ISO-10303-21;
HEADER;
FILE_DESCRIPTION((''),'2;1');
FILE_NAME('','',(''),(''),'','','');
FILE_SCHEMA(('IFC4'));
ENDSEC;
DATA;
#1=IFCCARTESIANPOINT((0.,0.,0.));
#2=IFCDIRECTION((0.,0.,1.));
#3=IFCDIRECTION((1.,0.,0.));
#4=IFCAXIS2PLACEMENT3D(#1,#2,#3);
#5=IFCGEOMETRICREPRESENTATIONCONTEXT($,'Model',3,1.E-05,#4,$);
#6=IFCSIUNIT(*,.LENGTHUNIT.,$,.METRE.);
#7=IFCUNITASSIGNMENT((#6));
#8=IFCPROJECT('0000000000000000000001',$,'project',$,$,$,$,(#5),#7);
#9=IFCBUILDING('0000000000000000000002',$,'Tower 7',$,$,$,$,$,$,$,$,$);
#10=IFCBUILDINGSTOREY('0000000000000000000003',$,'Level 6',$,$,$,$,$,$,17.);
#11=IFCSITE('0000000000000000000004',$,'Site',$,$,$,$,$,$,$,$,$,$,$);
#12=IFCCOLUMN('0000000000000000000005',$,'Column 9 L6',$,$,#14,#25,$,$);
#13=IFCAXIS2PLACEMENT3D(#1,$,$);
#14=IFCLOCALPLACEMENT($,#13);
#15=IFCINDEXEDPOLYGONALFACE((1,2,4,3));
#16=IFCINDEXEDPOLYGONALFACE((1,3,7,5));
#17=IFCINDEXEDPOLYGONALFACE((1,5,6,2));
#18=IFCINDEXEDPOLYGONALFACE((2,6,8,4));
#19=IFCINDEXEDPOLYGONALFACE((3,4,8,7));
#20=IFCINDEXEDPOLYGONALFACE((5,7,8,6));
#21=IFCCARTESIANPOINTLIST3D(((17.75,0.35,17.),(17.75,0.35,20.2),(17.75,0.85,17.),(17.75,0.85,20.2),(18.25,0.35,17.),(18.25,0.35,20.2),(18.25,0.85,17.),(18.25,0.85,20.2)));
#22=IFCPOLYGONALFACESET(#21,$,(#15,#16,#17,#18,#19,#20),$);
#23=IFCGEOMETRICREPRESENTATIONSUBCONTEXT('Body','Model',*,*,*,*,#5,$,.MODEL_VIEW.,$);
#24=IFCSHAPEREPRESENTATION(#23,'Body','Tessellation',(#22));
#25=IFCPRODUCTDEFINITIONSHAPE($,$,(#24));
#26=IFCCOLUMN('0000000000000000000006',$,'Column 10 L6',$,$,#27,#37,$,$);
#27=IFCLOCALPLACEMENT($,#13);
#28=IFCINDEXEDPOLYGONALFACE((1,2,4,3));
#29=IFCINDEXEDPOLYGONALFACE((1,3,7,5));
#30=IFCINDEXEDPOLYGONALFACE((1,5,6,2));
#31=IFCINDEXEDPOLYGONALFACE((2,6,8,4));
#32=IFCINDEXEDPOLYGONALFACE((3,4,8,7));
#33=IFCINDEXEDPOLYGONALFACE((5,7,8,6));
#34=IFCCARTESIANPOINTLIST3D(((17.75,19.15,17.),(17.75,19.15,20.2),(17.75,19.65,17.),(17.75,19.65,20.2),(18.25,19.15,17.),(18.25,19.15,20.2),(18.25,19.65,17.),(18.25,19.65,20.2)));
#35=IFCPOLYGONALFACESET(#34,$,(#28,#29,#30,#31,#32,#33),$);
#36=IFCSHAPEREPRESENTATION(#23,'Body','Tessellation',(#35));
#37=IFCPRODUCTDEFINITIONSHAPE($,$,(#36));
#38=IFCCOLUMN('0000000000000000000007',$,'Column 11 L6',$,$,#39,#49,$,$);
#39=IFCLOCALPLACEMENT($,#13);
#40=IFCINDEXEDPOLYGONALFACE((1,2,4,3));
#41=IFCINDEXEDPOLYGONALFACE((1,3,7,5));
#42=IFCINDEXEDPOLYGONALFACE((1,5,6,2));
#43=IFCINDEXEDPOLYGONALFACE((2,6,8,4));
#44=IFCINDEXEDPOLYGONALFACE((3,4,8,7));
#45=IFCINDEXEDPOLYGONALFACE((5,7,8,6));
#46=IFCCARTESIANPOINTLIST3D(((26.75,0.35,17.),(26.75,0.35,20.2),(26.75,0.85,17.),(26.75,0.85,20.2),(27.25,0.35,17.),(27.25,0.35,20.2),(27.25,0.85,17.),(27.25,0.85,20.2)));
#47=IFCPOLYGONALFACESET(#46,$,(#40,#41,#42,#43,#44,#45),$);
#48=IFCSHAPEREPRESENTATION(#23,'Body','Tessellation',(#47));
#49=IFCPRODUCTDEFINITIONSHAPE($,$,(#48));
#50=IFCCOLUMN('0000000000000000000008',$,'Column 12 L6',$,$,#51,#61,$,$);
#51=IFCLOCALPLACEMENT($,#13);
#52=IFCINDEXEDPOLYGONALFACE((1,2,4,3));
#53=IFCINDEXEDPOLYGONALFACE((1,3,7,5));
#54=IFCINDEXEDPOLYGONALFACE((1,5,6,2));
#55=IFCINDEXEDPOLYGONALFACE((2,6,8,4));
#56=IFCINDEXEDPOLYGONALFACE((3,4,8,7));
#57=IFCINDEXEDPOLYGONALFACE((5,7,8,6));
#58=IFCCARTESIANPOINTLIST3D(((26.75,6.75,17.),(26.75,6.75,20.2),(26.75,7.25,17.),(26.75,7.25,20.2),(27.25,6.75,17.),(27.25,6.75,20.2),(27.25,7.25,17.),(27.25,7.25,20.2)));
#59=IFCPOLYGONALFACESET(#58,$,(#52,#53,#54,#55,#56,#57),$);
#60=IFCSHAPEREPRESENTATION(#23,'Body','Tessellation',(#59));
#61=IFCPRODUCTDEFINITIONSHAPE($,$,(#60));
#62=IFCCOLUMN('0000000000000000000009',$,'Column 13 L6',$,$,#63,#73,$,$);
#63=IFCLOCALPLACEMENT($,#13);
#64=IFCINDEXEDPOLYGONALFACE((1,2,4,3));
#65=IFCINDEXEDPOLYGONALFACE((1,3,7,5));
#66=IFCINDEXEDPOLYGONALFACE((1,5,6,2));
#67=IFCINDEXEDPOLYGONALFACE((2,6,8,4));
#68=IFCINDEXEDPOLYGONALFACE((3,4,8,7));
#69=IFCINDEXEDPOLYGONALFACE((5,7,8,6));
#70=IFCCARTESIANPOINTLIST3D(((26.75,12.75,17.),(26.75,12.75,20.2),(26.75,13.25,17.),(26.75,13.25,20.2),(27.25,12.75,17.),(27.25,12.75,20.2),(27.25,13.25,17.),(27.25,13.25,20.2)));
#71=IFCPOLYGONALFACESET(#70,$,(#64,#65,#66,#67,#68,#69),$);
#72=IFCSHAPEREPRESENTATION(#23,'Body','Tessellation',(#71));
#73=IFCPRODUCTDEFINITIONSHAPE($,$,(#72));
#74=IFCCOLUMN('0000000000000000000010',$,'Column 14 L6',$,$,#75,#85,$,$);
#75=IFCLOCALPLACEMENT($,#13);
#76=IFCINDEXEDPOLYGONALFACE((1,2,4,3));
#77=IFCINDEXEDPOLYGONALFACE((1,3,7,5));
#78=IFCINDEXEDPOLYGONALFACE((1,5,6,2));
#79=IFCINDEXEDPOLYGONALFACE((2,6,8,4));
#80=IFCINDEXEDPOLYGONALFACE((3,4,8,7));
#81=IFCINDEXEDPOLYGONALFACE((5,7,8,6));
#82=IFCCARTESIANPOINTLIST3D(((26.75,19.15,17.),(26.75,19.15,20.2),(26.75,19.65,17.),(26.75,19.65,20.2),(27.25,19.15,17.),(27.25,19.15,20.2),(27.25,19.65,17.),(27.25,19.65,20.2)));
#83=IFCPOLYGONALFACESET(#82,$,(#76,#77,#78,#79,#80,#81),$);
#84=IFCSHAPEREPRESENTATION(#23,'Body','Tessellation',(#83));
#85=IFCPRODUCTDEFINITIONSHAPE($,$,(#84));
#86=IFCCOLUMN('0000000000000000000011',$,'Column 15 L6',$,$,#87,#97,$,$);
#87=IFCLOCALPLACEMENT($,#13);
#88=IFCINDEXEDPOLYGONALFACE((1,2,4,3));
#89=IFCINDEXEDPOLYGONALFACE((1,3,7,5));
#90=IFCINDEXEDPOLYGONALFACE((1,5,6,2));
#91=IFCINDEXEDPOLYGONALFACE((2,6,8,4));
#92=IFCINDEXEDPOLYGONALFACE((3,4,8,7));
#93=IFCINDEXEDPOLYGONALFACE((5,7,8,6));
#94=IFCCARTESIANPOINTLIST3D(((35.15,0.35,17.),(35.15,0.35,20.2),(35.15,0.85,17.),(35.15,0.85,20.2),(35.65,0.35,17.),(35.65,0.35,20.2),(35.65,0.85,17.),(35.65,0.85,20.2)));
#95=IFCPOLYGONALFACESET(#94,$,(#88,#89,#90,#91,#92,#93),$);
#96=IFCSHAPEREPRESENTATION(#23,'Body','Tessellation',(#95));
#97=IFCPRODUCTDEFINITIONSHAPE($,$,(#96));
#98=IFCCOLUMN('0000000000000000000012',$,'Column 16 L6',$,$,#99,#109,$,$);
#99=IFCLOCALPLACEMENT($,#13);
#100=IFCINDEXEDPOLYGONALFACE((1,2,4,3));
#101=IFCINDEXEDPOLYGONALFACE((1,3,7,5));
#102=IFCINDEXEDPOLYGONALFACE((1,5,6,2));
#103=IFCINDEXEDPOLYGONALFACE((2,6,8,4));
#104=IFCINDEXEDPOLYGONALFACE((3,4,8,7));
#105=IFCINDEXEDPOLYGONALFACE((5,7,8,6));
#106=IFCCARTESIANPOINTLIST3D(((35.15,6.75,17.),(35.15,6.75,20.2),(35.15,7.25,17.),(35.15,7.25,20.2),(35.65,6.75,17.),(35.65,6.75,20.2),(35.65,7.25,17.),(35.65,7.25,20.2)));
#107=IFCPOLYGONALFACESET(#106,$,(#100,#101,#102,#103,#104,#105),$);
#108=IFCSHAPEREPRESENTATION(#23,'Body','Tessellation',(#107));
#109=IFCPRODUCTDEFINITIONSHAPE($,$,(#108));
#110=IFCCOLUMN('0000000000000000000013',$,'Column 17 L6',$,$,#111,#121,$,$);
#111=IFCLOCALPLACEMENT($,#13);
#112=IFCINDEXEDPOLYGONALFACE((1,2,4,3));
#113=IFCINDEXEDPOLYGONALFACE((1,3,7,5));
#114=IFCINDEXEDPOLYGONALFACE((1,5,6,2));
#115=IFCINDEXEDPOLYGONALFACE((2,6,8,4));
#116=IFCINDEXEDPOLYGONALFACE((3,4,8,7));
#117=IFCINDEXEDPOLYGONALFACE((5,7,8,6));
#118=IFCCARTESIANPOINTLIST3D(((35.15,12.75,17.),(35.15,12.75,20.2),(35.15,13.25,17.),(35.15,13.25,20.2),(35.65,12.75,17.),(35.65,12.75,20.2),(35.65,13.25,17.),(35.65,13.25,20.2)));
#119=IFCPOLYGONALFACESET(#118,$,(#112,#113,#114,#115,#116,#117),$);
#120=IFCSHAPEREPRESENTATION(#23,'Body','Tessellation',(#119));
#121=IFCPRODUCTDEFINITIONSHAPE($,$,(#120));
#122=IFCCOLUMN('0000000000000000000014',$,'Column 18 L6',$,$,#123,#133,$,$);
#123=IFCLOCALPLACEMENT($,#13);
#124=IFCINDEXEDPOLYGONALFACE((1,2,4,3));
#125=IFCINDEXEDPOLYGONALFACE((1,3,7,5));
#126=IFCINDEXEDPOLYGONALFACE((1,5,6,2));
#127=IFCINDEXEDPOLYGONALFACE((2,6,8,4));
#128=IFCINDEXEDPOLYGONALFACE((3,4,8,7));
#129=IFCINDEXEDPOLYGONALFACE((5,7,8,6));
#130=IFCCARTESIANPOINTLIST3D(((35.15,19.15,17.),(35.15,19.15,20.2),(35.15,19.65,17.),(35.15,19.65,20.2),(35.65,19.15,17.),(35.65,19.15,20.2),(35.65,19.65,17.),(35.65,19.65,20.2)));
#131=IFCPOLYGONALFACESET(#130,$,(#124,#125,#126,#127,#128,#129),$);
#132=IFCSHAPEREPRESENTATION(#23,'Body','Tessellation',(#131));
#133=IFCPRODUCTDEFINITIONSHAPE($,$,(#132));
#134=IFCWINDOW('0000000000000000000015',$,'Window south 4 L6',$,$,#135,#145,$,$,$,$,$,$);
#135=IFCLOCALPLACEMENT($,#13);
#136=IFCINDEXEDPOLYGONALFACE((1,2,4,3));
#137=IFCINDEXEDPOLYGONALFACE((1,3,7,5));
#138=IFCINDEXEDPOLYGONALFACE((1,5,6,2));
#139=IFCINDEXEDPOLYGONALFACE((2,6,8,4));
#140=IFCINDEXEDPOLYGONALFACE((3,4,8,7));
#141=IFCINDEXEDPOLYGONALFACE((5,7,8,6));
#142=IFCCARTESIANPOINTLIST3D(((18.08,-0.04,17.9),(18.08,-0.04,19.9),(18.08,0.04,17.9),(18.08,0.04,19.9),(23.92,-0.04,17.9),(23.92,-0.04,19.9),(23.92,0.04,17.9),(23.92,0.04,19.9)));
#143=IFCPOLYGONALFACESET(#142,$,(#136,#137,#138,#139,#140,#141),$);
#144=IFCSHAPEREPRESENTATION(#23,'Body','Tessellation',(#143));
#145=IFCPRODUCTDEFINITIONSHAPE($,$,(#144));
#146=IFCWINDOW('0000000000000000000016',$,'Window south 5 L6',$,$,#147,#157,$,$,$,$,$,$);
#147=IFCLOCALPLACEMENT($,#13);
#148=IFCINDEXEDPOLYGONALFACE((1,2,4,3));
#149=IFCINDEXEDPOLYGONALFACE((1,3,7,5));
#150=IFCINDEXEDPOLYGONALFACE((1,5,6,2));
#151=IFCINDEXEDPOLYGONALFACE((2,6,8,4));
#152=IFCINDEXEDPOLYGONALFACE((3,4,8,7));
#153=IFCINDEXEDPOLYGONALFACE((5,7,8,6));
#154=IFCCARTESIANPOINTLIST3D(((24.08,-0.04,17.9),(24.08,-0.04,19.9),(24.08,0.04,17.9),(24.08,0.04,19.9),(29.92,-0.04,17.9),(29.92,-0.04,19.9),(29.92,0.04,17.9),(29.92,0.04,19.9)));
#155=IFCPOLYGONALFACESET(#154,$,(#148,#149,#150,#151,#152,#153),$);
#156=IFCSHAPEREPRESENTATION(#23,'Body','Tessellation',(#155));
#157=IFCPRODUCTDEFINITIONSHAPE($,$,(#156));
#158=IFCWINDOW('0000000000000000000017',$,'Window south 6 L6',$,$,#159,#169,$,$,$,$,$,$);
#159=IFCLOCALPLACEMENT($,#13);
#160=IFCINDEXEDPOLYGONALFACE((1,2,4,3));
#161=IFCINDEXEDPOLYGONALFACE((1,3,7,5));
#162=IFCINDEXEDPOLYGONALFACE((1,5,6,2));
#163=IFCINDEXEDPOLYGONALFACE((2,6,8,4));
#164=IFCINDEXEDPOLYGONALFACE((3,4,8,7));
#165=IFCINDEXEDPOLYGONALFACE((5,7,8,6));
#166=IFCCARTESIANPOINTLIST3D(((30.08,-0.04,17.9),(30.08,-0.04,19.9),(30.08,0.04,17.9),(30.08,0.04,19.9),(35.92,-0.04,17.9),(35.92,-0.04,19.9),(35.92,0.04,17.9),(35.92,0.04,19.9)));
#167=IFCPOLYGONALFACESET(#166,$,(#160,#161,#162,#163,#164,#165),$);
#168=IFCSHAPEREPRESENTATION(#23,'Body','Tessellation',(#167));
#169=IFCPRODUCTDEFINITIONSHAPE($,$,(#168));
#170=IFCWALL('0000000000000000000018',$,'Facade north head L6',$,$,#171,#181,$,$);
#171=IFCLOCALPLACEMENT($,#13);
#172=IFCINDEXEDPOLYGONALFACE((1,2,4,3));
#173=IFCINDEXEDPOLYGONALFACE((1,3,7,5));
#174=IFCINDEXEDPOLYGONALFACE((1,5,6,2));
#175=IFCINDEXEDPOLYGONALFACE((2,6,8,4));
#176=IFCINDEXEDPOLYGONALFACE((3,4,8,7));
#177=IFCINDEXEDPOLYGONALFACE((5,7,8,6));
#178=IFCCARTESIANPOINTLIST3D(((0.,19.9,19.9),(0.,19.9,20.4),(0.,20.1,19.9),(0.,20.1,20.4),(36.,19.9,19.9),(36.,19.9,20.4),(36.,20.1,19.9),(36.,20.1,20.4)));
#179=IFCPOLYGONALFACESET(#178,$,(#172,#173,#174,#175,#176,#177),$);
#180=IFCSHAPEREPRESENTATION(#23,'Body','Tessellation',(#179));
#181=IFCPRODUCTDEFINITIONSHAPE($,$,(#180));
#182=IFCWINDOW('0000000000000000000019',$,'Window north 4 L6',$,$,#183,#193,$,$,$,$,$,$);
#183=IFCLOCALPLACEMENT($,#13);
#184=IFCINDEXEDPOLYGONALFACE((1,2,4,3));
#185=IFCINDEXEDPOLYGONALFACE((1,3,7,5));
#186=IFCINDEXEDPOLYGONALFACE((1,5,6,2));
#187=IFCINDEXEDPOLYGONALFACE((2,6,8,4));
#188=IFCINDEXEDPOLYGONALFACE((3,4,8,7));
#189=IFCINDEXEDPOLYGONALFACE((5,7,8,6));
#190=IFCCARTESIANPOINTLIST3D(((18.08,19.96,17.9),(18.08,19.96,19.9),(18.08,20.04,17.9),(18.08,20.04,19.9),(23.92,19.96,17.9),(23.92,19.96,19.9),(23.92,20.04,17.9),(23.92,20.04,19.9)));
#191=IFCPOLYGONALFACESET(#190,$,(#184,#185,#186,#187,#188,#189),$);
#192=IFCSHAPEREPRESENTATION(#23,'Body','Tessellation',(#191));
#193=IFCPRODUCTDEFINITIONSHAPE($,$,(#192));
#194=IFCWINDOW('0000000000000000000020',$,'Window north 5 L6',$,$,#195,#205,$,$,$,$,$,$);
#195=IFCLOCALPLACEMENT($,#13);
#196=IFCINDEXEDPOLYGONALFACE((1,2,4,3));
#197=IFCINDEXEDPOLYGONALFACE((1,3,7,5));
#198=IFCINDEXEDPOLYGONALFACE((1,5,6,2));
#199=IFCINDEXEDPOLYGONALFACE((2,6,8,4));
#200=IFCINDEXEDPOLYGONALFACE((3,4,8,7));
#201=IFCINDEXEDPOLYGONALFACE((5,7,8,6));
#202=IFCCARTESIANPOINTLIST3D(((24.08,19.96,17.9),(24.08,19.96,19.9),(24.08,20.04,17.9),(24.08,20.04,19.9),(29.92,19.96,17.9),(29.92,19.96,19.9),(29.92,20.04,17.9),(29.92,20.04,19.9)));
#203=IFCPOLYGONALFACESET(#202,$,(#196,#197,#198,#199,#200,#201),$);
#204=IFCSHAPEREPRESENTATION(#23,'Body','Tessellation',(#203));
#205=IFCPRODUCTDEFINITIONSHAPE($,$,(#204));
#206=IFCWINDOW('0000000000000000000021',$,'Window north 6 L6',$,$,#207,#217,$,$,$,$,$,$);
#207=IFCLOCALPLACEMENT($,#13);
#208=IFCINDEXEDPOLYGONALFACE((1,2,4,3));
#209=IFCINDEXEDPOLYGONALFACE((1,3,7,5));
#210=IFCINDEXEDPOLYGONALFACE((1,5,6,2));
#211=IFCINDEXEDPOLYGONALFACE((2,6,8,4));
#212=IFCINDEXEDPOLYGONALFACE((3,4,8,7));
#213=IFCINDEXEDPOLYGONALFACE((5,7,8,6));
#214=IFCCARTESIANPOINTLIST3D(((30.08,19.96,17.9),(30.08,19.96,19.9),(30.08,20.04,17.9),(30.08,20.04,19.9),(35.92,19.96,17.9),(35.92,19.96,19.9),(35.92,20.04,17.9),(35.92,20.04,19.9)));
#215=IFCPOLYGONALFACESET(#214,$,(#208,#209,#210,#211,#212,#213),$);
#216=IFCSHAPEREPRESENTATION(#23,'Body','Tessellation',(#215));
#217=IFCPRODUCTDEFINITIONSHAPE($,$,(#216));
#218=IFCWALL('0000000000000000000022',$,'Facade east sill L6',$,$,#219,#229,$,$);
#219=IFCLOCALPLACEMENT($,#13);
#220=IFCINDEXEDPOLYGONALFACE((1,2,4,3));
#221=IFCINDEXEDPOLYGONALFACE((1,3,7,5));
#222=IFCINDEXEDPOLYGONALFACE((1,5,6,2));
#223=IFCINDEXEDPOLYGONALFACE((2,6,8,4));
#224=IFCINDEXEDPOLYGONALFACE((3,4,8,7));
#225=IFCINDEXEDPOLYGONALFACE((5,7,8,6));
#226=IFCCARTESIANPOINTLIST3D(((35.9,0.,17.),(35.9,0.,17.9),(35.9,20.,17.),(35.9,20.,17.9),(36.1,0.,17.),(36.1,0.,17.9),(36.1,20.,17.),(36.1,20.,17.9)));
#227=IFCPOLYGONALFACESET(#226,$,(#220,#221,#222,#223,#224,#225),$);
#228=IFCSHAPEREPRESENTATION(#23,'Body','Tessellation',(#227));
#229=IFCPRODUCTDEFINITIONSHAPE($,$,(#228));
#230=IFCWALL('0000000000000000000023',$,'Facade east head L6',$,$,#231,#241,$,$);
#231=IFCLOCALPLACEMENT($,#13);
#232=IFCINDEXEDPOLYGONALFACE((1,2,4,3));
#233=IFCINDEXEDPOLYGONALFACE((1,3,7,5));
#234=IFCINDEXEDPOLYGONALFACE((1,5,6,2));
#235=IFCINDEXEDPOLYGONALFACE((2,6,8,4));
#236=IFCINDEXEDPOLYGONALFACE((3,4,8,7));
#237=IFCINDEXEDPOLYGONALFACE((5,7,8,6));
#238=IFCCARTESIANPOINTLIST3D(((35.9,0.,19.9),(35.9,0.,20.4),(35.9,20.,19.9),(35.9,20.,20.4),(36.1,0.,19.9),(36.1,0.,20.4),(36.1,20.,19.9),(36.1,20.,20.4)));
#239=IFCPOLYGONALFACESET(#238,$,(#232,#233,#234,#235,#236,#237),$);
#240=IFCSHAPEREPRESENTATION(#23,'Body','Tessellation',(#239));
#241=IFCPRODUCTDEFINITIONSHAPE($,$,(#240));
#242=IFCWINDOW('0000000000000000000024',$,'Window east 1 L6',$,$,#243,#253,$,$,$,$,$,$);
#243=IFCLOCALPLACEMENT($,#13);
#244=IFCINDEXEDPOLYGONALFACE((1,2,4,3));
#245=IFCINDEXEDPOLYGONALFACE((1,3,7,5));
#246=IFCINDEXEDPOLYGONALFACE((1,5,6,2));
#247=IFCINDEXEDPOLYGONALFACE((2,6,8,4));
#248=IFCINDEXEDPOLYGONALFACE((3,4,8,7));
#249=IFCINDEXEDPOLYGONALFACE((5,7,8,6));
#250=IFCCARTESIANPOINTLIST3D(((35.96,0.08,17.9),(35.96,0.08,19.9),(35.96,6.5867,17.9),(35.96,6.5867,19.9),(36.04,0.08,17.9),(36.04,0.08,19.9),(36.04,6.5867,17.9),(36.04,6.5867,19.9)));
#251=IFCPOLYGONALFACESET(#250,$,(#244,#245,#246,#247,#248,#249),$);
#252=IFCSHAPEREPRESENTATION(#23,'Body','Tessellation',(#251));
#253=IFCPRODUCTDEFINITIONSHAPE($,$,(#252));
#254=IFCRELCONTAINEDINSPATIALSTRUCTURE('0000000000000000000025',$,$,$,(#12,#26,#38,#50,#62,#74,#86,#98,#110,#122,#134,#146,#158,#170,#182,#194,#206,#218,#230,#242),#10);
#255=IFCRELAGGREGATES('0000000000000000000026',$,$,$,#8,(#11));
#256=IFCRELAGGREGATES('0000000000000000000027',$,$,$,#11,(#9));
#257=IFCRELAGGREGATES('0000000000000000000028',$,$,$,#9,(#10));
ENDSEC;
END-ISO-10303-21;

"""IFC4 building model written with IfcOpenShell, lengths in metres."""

from ifc_helpers import new_model, si_unit, frame, origin, origin_with_axes, origin_2d, place, context, subcontext, project, spatial, rectangle, extrude, element, save


model = new_model("IFC4")

# Units and contexts
model_context = context("Model", 3, precision=1e-05, world=origin_with_axes())
body_context = subcontext(model_context, "Body", "Model", "MODEL_VIEW")
ifc_project = project(units=[si_unit("LENGTHUNIT", "METRE")], contexts=[model_context])

# Site, building, storey
site = spatial("IfcSite", under=ifc_project, Name="Site")
building = spatial("IfcBuilding", under=site, Name="Tower 7")
storey = spatial("IfcBuildingStorey", under=building, Name="Level 6", Elevation=17.0)

# Columns
for number, where, z_axis, x_axis, name in (
    (1, (18.0, 0.6, 17.0), (0.0, 0.0, 1.0), (1.0, 0.0, 0.0), "Column 9 L6"),
    (2, (18.0, 19.4, 17.0), (0.0, 0.0, 1.0), (1.0, 0.0, 0.0), "Column 10 L6"),
    (3, (27.0, 0.6, 17.0), (0.0, 0.0, 1.0), (1.0, 0.0, 0.0), "Column 11 L6"),
    (4, (27.0, 7.0, 17.0), (0.0, 0.0, 1.0), (1.0, 0.0, 0.0), "Column 12 L6"),
    (5, (27.0, 13.0, 17.0), (0.0, 0.0, 1.0), (1.0, 0.0, 0.0), "Column 13 L6"),
    (6, (27.0, 19.4, 17.0), (0.0, 0.0, 1.0), (1.0, 0.0, 0.0), "Column 14 L6"),
    (7, (35.4, 0.6, 17.0), (0.0, 0.0, 1.0), (1.0, 0.0, 0.0), "Column 15 L6"),
    (8, (35.4, 7.0, 17.0), (0.0, 0.0, 1.0), (1.0, 0.0, 0.0), "Column 16 L6"),
    (9, (35.4, 13.0, 17.0), (0.0, 0.0, 1.0), (1.0, 0.0, 0.0), "Column 17 L6"),
    (10, (35.4, 19.4, 17.0), (0.0, 0.0, 1.0), (1.0, 0.0, 0.0), "Column 18 L6"),
):
    element("IfcColumn", number, at=place(None, frame(where, z_axis=z_axis, x_axis=x_axis)), inside=storey, Name=name, context=body_context, shape_type="SweptSolid", body=[
        extrude(rectangle(XDim=0.5, YDim=0.5, at=origin_2d()), origin(), (0.0, 0.0, 1.0), 3.2),
    ])

# Windows
for number, where, z_axis, x_axis, name in (
    (11, (21.0, 0.0, 17.9), (0.0, 0.0, 1.0), (1.0, 0.0, 0.0), "Window south 4 L6"),
    (12, (27.0, 0.0, 17.9), (0.0, 0.0, 1.0), (1.0, 0.0, 0.0), "Window south 5 L6"),
    (13, (33.0, 0.0, 17.9), (0.0, 0.0, 1.0), (1.0, 0.0, 0.0), "Window south 6 L6"),
):
    element("IfcWindow", number, at=place(None, frame(where, z_axis=z_axis, x_axis=x_axis)), inside=storey, Name=name, context=body_context, shape_type="SweptSolid", body=[
        extrude(rectangle(XDim=5.84, YDim=0.08, at=origin_2d()), origin(), (0.0, 0.0, 1.0), 2.0),
    ])

# Wall
wall_1_placement = place(None, frame((18.0, 20.0, 19.9), z_axis=(0.0, 0.0, 1.0), x_axis=(1.0, 0.0, 0.0)))
element("IfcWall", 14, at=wall_1_placement, inside=storey, Name="Facade north head L6", context=body_context, shape_type="SweptSolid", body=[
    extrude(rectangle(XDim=36.0, YDim=0.2, at=origin_2d()), origin(), (0.0, 0.0, 1.0), 0.5),
])

# Windows
for number, where, z_axis, x_axis, name in (
    (15, (21.0, 20.0, 17.9), (0.0, 0.0, 1.0), (1.0, 0.0, 0.0), "Window north 4 L6"),
    (16, (27.0, 20.0, 17.9), (0.0, 0.0, 1.0), (1.0, 0.0, 0.0), "Window north 5 L6"),
    (17, (33.0, 20.0, 17.9), (0.0, 0.0, 1.0), (1.0, 0.0, 0.0), "Window north 6 L6"),
):
    element("IfcWindow", number, at=place(None, frame(where, z_axis=z_axis, x_axis=x_axis)), inside=storey, Name=name, context=body_context, shape_type="SweptSolid", body=[
        extrude(rectangle(XDim=5.84, YDim=0.08, at=origin_2d()), origin(), (0.0, 0.0, 1.0), 2.0),
    ])

# Walls
wall_2_placement = place(None, frame((36.0, 10.0, 17.0), z_axis=(0.0, 0.0, 1.0), x_axis=(1.0, 0.0, 0.0)))
element("IfcWall", 18, at=wall_2_placement, inside=storey, Name="Facade east sill L6", context=body_context, shape_type="SweptSolid", body=[
    extrude(rectangle(XDim=0.2, YDim=20.0, at=origin_2d()), origin(), (0.0, 0.0, 1.0), 0.9),
])
wall_3_placement = place(None, frame((36.0, 10.0, 19.9), z_axis=(0.0, 0.0, 1.0), x_axis=(1.0, 0.0, 0.0)))
element("IfcWall", 19, at=wall_3_placement, inside=storey, Name="Facade east head L6", context=body_context, shape_type="SweptSolid", body=[
    extrude(rectangle(XDim=0.2, YDim=20.0, at=origin_2d()), origin(), (0.0, 0.0, 1.0), 0.5),
])

# Window
for number, where, z_axis, x_axis, name in (
    (20, (36.0, 3.3333, 17.9), (0.0, 0.0, 1.0), (1.0, 0.0, 0.0), "Window east 1 L6"),
):
    element("IfcWindow", number, at=place(None, frame(where, z_axis=z_axis, x_axis=x_axis)), inside=storey, Name=name, context=body_context, shape_type="SweptSolid", body=[
        extrude(rectangle(XDim=0.08, YDim=6.5067, at=origin_2d()), origin(), (0.0, 0.0, 1.0), 2.0),
    ])

save(model, "model.ifc")
